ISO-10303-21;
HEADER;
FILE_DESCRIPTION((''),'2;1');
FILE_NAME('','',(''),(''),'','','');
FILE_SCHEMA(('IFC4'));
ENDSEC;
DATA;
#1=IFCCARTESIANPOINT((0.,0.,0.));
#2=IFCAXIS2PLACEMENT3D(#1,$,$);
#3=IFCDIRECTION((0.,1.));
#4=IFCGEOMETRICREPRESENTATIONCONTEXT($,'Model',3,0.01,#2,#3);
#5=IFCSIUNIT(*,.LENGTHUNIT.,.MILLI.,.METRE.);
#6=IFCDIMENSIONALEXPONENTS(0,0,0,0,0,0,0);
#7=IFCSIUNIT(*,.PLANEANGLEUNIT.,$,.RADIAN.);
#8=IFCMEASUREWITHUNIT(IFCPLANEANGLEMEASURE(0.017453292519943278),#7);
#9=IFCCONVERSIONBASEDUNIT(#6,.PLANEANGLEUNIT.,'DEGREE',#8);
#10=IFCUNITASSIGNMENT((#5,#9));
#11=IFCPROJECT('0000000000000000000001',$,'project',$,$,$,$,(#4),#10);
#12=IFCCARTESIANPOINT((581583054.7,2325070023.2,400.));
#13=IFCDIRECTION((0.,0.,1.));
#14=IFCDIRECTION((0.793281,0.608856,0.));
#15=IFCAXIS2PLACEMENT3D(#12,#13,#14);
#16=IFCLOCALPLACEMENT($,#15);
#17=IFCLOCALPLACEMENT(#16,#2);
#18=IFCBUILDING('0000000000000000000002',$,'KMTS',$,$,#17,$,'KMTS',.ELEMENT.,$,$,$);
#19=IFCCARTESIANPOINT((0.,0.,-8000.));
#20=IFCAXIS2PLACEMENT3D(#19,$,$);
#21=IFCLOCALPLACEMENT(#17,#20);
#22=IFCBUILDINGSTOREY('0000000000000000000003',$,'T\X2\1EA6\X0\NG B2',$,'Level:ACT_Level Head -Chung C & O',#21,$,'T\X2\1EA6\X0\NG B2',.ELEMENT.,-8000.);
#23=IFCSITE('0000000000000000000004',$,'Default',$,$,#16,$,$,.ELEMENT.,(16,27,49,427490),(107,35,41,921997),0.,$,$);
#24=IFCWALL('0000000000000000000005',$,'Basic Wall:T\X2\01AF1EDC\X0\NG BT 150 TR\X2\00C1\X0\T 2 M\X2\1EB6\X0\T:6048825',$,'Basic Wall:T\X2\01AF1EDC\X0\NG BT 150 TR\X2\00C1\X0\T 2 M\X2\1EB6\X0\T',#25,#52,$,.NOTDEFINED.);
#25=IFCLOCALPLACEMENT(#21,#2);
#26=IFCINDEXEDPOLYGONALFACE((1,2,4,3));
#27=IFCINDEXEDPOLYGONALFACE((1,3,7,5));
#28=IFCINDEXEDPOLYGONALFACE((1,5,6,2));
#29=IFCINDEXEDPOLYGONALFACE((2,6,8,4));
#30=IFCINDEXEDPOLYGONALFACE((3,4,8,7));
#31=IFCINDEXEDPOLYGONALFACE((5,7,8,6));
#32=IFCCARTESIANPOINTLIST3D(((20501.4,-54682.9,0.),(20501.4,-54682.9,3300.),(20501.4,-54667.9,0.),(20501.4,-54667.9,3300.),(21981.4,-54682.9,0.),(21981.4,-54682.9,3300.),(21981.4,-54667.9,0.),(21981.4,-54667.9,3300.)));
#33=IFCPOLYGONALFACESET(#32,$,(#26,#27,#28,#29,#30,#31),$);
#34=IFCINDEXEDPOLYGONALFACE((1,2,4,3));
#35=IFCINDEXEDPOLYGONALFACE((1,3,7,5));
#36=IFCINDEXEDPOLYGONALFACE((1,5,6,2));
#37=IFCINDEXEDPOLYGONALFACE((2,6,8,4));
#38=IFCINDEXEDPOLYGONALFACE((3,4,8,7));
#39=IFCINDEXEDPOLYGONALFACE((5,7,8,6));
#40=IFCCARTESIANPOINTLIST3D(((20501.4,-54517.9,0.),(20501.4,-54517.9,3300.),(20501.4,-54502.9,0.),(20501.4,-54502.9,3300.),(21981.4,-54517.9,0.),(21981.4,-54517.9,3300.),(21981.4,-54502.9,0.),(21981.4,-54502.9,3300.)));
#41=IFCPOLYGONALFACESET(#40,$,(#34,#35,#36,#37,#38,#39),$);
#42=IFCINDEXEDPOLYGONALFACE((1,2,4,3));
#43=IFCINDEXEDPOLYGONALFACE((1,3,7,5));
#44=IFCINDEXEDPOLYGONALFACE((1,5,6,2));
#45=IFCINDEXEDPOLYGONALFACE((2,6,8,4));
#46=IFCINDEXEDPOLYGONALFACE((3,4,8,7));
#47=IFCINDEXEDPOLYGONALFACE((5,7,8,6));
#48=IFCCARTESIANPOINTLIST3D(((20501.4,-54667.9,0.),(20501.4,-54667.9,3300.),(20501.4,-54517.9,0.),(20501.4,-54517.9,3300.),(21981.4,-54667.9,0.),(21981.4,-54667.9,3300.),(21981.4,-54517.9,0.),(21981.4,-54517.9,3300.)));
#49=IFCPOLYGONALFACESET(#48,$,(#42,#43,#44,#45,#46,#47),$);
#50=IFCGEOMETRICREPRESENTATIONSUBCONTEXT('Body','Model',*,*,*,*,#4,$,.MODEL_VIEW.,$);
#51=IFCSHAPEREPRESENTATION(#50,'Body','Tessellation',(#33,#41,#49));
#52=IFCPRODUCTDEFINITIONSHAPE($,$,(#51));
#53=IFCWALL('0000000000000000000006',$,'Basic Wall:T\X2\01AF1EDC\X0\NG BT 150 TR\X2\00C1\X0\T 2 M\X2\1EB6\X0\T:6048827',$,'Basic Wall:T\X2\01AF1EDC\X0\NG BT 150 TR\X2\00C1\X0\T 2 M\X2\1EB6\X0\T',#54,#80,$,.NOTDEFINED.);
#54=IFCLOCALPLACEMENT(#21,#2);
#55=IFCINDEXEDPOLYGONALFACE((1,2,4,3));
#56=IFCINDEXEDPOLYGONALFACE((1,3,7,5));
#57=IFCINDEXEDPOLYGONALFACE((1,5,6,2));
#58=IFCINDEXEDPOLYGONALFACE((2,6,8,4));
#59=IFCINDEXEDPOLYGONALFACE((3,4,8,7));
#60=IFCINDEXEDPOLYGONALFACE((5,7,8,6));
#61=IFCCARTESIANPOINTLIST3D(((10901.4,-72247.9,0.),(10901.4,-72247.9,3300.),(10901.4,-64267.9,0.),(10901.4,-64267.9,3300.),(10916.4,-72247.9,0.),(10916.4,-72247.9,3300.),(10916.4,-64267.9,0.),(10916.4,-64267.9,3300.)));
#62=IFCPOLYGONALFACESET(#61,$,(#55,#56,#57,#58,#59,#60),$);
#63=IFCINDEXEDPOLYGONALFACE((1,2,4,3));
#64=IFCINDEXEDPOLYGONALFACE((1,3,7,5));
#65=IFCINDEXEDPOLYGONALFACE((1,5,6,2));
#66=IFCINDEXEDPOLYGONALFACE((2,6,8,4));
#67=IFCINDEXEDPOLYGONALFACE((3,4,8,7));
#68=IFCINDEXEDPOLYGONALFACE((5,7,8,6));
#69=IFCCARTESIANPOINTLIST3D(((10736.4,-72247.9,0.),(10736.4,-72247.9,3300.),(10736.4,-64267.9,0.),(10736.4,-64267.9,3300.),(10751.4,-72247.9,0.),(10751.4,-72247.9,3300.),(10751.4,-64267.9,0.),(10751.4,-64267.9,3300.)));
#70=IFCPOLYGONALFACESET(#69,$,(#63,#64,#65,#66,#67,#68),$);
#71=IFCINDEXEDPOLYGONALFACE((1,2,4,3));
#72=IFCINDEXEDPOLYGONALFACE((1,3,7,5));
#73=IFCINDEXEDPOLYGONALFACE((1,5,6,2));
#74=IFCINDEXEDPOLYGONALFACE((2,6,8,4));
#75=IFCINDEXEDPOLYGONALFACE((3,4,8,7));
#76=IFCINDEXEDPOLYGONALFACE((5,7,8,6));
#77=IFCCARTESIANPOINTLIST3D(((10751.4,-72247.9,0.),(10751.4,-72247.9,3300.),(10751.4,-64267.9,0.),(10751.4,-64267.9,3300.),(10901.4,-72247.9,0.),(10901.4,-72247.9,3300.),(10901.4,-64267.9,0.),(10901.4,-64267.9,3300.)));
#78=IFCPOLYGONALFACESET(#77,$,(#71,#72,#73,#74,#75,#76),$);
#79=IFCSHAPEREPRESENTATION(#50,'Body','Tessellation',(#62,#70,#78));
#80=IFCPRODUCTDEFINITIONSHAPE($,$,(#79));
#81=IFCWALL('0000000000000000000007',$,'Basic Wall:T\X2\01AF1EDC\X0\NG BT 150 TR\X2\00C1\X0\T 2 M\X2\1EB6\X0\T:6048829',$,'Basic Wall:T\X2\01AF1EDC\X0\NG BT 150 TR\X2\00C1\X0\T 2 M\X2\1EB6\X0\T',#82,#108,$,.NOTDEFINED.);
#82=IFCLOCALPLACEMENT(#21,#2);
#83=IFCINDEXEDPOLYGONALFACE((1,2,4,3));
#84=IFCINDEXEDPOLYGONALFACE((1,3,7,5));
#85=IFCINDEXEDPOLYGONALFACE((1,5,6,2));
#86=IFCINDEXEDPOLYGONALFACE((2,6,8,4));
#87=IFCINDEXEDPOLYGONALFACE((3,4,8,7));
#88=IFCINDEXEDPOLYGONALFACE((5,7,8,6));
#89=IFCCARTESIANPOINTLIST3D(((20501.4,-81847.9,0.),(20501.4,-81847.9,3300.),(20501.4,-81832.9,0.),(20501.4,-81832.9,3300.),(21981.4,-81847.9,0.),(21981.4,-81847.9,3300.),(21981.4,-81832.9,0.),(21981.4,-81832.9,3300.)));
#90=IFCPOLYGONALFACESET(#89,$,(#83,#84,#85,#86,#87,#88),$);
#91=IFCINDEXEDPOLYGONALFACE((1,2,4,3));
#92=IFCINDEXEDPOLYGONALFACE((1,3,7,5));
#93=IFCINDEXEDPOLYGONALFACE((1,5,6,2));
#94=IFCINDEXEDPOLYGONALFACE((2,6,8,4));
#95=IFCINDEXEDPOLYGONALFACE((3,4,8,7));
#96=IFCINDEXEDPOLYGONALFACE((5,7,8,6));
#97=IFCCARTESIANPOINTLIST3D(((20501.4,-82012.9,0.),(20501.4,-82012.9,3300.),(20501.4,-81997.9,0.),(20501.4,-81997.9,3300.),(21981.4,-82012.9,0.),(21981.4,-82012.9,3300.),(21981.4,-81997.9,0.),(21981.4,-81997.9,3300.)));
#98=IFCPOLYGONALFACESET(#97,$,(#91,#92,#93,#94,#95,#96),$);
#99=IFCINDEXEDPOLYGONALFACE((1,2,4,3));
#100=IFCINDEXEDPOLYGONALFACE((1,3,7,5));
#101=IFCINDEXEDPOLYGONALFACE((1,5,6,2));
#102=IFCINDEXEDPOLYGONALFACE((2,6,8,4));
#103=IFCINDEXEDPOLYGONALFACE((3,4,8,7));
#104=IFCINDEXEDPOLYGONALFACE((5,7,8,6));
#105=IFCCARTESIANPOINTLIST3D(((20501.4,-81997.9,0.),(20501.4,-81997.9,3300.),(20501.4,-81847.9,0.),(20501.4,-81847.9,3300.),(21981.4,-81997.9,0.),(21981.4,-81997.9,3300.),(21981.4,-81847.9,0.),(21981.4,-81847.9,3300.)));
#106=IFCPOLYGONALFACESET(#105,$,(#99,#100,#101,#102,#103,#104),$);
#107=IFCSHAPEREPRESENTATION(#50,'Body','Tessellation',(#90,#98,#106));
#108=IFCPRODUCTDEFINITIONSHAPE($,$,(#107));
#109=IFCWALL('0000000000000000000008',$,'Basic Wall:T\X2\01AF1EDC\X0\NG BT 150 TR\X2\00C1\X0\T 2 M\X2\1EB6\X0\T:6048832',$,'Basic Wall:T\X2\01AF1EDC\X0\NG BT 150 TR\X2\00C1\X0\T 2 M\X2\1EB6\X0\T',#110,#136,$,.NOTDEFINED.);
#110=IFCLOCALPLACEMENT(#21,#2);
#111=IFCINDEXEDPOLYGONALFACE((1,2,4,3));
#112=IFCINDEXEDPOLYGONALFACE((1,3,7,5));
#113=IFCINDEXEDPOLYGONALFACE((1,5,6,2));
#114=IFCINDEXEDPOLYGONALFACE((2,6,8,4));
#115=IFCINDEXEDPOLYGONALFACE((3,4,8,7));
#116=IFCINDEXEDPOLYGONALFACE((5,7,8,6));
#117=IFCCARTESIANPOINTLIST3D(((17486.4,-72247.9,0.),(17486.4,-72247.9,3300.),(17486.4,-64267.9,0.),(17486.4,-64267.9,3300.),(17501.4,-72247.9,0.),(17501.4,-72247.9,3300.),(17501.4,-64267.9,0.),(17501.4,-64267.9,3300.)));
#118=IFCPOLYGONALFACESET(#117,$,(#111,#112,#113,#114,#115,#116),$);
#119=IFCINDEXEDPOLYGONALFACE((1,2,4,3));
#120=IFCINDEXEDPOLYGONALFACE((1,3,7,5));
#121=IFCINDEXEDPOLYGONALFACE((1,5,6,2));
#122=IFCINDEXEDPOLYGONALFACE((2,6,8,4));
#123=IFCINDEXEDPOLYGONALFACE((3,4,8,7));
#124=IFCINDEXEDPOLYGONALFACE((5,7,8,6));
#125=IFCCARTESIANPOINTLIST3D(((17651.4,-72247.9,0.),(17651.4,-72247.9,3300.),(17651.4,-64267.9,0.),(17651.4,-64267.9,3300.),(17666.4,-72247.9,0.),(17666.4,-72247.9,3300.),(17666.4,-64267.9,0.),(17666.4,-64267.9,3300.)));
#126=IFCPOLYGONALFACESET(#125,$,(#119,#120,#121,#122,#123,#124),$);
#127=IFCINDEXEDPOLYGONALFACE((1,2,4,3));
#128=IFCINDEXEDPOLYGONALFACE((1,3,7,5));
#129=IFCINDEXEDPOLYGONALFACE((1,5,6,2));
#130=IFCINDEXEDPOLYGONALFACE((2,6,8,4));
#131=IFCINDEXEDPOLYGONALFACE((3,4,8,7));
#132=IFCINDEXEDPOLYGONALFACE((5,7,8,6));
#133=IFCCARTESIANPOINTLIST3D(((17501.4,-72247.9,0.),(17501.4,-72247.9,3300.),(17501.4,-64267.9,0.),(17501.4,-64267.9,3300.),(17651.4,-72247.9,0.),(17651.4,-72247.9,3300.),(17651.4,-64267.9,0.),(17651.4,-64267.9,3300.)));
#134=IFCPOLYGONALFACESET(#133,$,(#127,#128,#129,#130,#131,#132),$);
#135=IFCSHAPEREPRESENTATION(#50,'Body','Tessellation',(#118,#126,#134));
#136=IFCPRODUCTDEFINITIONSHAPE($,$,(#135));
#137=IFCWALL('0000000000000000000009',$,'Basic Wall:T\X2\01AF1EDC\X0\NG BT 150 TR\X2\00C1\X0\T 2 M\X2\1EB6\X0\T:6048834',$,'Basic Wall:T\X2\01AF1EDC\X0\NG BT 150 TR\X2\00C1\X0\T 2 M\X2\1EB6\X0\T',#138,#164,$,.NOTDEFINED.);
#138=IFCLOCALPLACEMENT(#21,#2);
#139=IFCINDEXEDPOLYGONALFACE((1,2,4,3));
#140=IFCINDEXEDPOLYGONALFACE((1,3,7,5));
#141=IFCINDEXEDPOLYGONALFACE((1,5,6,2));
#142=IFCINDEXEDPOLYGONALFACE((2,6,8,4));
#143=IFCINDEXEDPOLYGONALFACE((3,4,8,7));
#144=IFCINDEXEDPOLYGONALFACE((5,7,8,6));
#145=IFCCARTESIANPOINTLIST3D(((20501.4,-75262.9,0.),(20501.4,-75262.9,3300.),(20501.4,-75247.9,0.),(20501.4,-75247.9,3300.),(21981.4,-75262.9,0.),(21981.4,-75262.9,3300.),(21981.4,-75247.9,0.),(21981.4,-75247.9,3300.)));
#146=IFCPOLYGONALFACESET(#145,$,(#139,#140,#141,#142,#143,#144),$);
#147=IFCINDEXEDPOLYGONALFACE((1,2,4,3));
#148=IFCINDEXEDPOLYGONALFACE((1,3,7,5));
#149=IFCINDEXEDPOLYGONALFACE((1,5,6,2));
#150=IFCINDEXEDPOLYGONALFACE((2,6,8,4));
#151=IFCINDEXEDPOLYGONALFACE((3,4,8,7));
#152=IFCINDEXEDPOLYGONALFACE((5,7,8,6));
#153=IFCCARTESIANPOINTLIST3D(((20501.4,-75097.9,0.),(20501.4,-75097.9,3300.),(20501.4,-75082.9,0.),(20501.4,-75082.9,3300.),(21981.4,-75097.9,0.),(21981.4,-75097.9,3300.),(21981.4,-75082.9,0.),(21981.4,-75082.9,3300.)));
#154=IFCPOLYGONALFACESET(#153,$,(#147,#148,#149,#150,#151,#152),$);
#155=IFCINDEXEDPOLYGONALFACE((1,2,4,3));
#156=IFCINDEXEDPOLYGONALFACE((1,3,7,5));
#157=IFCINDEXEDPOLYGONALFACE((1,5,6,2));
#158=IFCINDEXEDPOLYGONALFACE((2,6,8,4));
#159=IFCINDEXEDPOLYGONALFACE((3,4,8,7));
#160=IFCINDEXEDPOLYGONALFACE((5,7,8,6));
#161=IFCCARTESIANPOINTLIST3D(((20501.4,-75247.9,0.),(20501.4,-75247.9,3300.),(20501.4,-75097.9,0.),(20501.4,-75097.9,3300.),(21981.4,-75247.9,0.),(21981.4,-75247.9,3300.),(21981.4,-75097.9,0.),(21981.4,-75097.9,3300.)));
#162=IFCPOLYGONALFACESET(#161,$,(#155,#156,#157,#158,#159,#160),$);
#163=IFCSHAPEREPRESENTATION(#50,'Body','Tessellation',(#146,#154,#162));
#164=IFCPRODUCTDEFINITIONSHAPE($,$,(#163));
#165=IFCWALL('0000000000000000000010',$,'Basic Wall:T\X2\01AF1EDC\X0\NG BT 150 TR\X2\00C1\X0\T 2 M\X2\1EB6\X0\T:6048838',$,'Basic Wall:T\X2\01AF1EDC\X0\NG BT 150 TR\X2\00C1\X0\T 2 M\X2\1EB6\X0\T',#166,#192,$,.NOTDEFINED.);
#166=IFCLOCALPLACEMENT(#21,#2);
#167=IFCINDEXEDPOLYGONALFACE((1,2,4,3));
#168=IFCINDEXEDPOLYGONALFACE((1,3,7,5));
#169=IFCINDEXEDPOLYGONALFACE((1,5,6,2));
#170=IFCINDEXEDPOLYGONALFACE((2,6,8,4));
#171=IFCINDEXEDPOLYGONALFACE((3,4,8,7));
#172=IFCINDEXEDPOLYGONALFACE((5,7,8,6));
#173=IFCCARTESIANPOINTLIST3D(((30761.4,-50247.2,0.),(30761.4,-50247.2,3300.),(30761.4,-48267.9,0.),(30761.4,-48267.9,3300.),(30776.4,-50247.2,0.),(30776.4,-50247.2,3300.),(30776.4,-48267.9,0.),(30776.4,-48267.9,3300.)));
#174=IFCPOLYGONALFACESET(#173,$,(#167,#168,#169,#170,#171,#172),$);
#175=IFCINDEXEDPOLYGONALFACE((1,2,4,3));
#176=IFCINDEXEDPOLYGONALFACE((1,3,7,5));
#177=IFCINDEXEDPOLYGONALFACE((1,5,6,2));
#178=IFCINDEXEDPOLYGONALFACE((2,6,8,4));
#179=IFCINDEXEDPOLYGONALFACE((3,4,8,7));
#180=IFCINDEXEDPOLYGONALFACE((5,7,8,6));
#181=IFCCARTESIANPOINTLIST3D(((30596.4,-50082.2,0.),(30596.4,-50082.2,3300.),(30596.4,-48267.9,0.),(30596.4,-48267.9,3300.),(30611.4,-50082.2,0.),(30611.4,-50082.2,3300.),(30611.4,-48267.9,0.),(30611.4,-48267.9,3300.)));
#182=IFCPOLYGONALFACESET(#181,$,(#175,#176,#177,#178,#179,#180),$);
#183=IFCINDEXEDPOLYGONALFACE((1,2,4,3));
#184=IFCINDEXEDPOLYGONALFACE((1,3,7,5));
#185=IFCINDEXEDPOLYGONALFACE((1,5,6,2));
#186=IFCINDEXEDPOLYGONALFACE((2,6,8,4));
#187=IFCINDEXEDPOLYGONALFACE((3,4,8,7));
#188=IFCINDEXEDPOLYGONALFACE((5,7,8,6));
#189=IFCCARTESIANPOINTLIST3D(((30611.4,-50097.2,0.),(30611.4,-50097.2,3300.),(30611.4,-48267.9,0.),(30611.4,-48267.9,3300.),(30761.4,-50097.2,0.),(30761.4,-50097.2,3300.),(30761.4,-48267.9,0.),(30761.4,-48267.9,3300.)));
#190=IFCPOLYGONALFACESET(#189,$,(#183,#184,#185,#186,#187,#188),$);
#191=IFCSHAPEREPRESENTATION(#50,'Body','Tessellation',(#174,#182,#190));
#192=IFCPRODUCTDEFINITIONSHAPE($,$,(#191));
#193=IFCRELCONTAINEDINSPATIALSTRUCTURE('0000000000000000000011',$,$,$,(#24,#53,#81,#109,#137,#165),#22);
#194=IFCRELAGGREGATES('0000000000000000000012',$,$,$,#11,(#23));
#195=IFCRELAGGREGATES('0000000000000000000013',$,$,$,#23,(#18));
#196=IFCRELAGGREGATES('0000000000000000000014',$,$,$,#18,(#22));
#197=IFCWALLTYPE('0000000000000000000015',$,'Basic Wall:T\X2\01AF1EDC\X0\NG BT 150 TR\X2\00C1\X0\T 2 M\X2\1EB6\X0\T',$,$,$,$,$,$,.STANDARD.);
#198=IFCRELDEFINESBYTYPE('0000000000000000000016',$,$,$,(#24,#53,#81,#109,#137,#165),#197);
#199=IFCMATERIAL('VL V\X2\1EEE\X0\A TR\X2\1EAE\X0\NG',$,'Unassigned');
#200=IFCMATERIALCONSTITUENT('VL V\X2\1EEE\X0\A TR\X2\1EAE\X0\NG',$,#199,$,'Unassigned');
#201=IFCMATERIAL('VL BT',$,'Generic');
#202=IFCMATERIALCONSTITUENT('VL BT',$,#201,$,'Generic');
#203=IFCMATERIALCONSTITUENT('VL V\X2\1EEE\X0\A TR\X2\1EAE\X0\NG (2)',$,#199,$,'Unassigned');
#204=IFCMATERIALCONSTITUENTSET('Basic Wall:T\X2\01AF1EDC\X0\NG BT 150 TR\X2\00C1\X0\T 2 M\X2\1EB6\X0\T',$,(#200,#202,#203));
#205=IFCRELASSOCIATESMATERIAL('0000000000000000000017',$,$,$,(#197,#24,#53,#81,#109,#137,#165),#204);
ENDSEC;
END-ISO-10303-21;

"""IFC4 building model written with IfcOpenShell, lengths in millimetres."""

from ifc_helpers import new_model, entity, si_unit, converted_unit, direction, frame, origin, place, context, subcontext, project, spatial, indexed_curve, outline, extrude, material, constituent, constituent_set, type_object, element, save


model = new_model("IFC4")

# Units and contexts
model_context = context("Model", 3, precision=0.01, world=origin(), true_north=direction((0.0, 1.0)))
body_context = subcontext(model_context, "Body", "Model", "MODEL_VIEW")
ifc_project = project(units=[si_unit("LENGTHUNIT", "METRE", prefix="MILLI"), converted_unit("PLANEANGLEUNIT", "DEGREE", entity("IfcPlaneAngleMeasure", 0.017453292519943278), si_unit("PLANEANGLEUNIT", "RADIAN"), dimensions=[0, 0, 0, 0, 0, 0, 0])], contexts=[model_context])

# Site, building, storey
site_placement = place(None, frame((581583054.7, 2325070023.2, 400.0), z_axis=(0.0, 0.0, 1.0), x_axis=(0.793281, 0.608856, 0.0)))
site = spatial("IfcSite", under=ifc_project, at=site_placement, Name="Default", CompositionType="ELEMENT", RefLatitude=(16, 27, 49, 427490), RefLongitude=(107, 35, 41, 921997), RefElevation=0.0)
building_placement = place(site_placement, origin())
building = spatial("IfcBuilding", under=site, at=building_placement, Name="KMTS", LongName="KMTS", CompositionType="ELEMENT")
storey_placement = place(building_placement, frame((0.0, 0.0, -8000.0)))
storey = spatial("IfcBuildingStorey", under=building, at=storey_placement, Name="TẦNG B2", ObjectType="Level:ACT_Level Head -Chung C & O", LongName="TẦNG B2", CompositionType="ELEMENT", Elevation=-8000.0)

# Shared definitions
ifc_material_1 = material(Name="VL VỮA TRẮNG", Category="Unassigned")
ifc_constituent_1 = constituent(ifc_material_1, Name="VL VỮA TRẮNG", Category="Unassigned")
ifc_material_2 = material(Name="VL BT", Category="Generic")
ifc_constituent_2 = constituent(ifc_material_2, Name="VL BT", Category="Generic")
ifc_constituent_3 = constituent(ifc_material_1, Name="VL VỮA TRẮNG (2)", Category="Unassigned")
ifc_constituent_set_1 = constituent_set(constituents=[ifc_constituent_1, ifc_constituent_2, ifc_constituent_3], Name="Basic Wall:TƯỜNG BT 150 TRÁT 2 MẶT")
wall_type_1 = type_object("IfcWallType", Name="Basic Wall:TƯỜNG BT 150 TRÁT 2 MẶT", PredefinedType="STANDARD", material=ifc_constituent_set_1)

# Walls
wall_1_placement = place(storey_placement, frame((20501.4, -54592.9, 0.0)))
element("IfcWall", 1, at=wall_1_placement, inside=storey, type_object=wall_type_1, material=ifc_constituent_set_1, Name="Basic Wall:TƯỜNG BT 150 TRÁT 2 MẶT:6048825", ObjectType="Basic Wall:TƯỜNG BT 150 TRÁT 2 MẶT", PredefinedType="NOTDEFINED", context=body_context, shape_type="SweptSolid", body=[
    extrude(outline(indexed_curve([(-7.5, -740.0), (7.5, -740.0), (7.5, 740.0), (-7.5, 740.0), (-7.5, -740.0)], self_intersect=False)), frame((740.0, -82.5, 0.0), z_axis=(0.0, 0.0, 1.0), x_axis=(0.0, 1.0, 0.0)), (0.0, 0.0, 1.0), 3300.0),
    extrude(outline(indexed_curve([(-7.5, -740.0), (7.5, -740.0), (7.5, 740.0), (-7.5, 740.0), (-7.5, -740.0)], self_intersect=False)), frame((740.0, 82.5, 0.0), z_axis=(0.0, 0.0, 1.0), x_axis=(0.0, -1.0, 0.0)), (0.0, 0.0, 1.0), 3300.0),
    extrude(outline(indexed_curve([(-740.0, -75.0), (740.0, -75.0), (740.0, 75.0), (-740.0, 75.0), (-740.0, -75.0)], self_intersect=False)), frame((740.0, 0.0, 0.0)), (0.0, 0.0, 1.0), 3300.0),
])
wall_2_placement = place(storey_placement, frame((10826.4, -72247.9, 0.0), z_axis=(0.0, 0.0, 1.0), x_axis=(0.0, 1.0, 0.0)))
element("IfcWall", 2, at=wall_2_placement, inside=storey, type_object=wall_type_1, material=ifc_constituent_set_1, Name="Basic Wall:TƯỜNG BT 150 TRÁT 2 MẶT:6048827", ObjectType="Basic Wall:TƯỜNG BT 150 TRÁT 2 MẶT", PredefinedType="NOTDEFINED", context=body_context, shape_type="SweptSolid", body=[
    extrude(outline(indexed_curve([(-7.5, -3990.0), (7.5, -3990.0), (7.5, 3990.0), (-7.5, 3990.0), (-7.5, -3990.0)], self_intersect=False)), frame((3990.0, -82.5, 0.0), z_axis=(0.0, 0.0, 1.0), x_axis=(0.0, 1.0, 0.0)), (0.0, 0.0, 1.0), 3300.0),
    extrude(outline(indexed_curve([(-7.5, -3990.0), (7.5, -3990.0), (7.5, 3990.0), (-7.5, 3990.0), (-7.5, -3990.0)], self_intersect=False)), frame((3990.0, 82.5, 0.0), z_axis=(0.0, 0.0, 1.0), x_axis=(0.0, -1.0, 0.0)), (0.0, 0.0, 1.0), 3300.0),
    extrude(outline(indexed_curve([(-3990.0, -75.0), (3990.0, -75.0), (3990.0, 75.0), (-3990.0, 75.0), (-3990.0, -75.0)], self_intersect=False)), frame((3990.0, 0.0, 0.0)), (0.0, 0.0, 1.0), 3300.0),
])
wall_3_placement = place(storey_placement, frame((21981.4, -81922.9, 0.0), z_axis=(0.0, 0.0, 1.0), x_axis=(-1.0, 0.0, 0.0)))
element("IfcWall", 3, at=wall_3_placement, inside=storey, type_object=wall_type_1, material=ifc_constituent_set_1, Name="Basic Wall:TƯỜNG BT 150 TRÁT 2 MẶT:6048829", ObjectType="Basic Wall:TƯỜNG BT 150 TRÁT 2 MẶT", PredefinedType="NOTDEFINED", context=body_context, shape_type="SweptSolid", body=[
    extrude(outline(indexed_curve([(-7.5, -740.0), (7.5, -740.0), (7.5, 740.0), (-7.5, 740.0), (-7.5, -740.0)], self_intersect=False)), frame((740.0, -82.5, 0.0), z_axis=(0.0, 0.0, 1.0), x_axis=(0.0, 1.0, 0.0)), (0.0, 0.0, 1.0), 3300.0),
    extrude(outline(indexed_curve([(-7.5, -740.0), (7.5, -740.0), (7.5, 740.0), (-7.5, 740.0), (-7.5, -740.0)], self_intersect=False)), frame((740.0, 82.5, 0.0), z_axis=(0.0, 0.0, 1.0), x_axis=(0.0, -1.0, 0.0)), (0.0, 0.0, 1.0), 3300.0),
    extrude(outline(indexed_curve([(-740.0, -75.0), (740.0, -75.0), (740.0, 75.0), (-740.0, 75.0), (-740.0, -75.0)], self_intersect=False)), frame((740.0, 0.0, 0.0)), (0.0, 0.0, 1.0), 3300.0),
])

# Walls
wall_4_placement = place(storey_placement, frame((17576.4, -64267.9, 0.0), z_axis=(0.0, 0.0, 1.0), x_axis=(0.0, -1.0, 0.0)))
element("IfcWall", 4, at=wall_4_placement, inside=storey, type_object=wall_type_1, material=ifc_constituent_set_1, Name="Basic Wall:TƯỜNG BT 150 TRÁT 2 MẶT:6048832", ObjectType="Basic Wall:TƯỜNG BT 150 TRÁT 2 MẶT", PredefinedType="NOTDEFINED", context=body_context, shape_type="SweptSolid", body=[
    extrude(outline(indexed_curve([(-7.5, -3990.0), (7.5, -3990.0), (7.5, 3990.0), (-7.5, 3990.0), (-7.5, -3990.0)], self_intersect=False)), frame((3990.0, -82.5, 0.0), z_axis=(0.0, 0.0, 1.0), x_axis=(0.0, 1.0, 0.0)), (0.0, 0.0, 1.0), 3300.0),
    extrude(outline(indexed_curve([(-7.5, -3990.0), (7.5, -3990.0), (7.5, 3990.0), (-7.5, 3990.0), (-7.5, -3990.0)], self_intersect=False)), frame((3990.0, 82.5, 0.0), z_axis=(0.0, 0.0, 1.0), x_axis=(0.0, -1.0, 0.0)), (0.0, 0.0, 1.0), 3300.0),
    extrude(outline(indexed_curve([(-3990.0, -75.0), (3990.0, -75.0), (3990.0, 75.0), (-3990.0, 75.0), (-3990.0, -75.0)], self_intersect=False)), frame((3990.0, 0.0, 0.0)), (0.0, 0.0, 1.0), 3300.0),
])
wall_5_placement = place(storey_placement, frame((20501.4, -75172.9, 0.0)))
element("IfcWall", 5, at=wall_5_placement, inside=storey, type_object=wall_type_1, material=ifc_constituent_set_1, Name="Basic Wall:TƯỜNG BT 150 TRÁT 2 MẶT:6048834", ObjectType="Basic Wall:TƯỜNG BT 150 TRÁT 2 MẶT", PredefinedType="NOTDEFINED", context=body_context, shape_type="SweptSolid", body=[
    extrude(outline(indexed_curve([(-7.5, -740.0), (7.5, -740.0), (7.5, 740.0), (-7.5, 740.0), (-7.5, -740.0)], self_intersect=False)), frame((740.0, -82.5, 0.0), z_axis=(0.0, 0.0, 1.0), x_axis=(0.0, 1.0, 0.0)), (0.0, 0.0, 1.0), 3300.0),
    extrude(outline(indexed_curve([(-7.5, -740.0), (7.5, -740.0), (7.5, 740.0), (-7.5, 740.0), (-7.5, -740.0)], self_intersect=False)), frame((740.0, 82.5, 0.0), z_axis=(0.0, 0.0, 1.0), x_axis=(0.0, -1.0, 0.0)), (0.0, 0.0, 1.0), 3300.0),
    extrude(outline(indexed_curve([(-740.0, -75.0), (740.0, -75.0), (740.0, 75.0), (-740.0, 75.0), (-740.0, -75.0)], self_intersect=False)), frame((740.0, 0.0, 0.0)), (0.0, 0.0, 1.0), 3300.0),
])

# Wall
wall_6_placement = place(storey_placement, frame((30686.4, -50082.2, 0.0), z_axis=(0.0, 0.0, 1.0), x_axis=(0.0, 1.0, 0.0)))
element("IfcWall", 6, at=wall_6_placement, inside=storey, type_object=wall_type_1, material=ifc_constituent_set_1, Name="Basic Wall:TƯỜNG BT 150 TRÁT 2 MẶT:6048838", ObjectType="Basic Wall:TƯỜNG BT 150 TRÁT 2 MẶT", PredefinedType="NOTDEFINED", context=body_context, shape_type="SweptSolid", body=[
    extrude(outline(indexed_curve([(-7.5, -989.6), (7.5, -989.6), (7.5, 989.6), (-7.5, 989.6), (-7.5, -989.6)], self_intersect=False)), frame((824.6, -82.5, 0.0), z_axis=(0.0, 0.0, 1.0), x_axis=(0.0, 1.0, 0.0)), (0.0, 0.0, 1.0), 3300.0),
    extrude(outline(indexed_curve([(-7.5, -907.1), (7.5, -907.1), (7.5, 907.1), (-7.5, 907.1), (-7.5, -907.1)], self_intersect=False)), frame((907.1, 82.5, 0.0), z_axis=(0.0, 0.0, 1.0), x_axis=(0.0, -1.0, 0.0)), (0.0, 0.0, 1.0), 3300.0),
    extrude(outline(indexed_curve([(-914.6, -75.0), (914.6, -75.0), (914.6, 75.0), (-914.6, 75.0), (-914.6, -75.0)], self_intersect=False)), frame((899.6, 0.0, 0.0)), (0.0, 0.0, 1.0), 3300.0),
])

save(model, "model.ifc")
